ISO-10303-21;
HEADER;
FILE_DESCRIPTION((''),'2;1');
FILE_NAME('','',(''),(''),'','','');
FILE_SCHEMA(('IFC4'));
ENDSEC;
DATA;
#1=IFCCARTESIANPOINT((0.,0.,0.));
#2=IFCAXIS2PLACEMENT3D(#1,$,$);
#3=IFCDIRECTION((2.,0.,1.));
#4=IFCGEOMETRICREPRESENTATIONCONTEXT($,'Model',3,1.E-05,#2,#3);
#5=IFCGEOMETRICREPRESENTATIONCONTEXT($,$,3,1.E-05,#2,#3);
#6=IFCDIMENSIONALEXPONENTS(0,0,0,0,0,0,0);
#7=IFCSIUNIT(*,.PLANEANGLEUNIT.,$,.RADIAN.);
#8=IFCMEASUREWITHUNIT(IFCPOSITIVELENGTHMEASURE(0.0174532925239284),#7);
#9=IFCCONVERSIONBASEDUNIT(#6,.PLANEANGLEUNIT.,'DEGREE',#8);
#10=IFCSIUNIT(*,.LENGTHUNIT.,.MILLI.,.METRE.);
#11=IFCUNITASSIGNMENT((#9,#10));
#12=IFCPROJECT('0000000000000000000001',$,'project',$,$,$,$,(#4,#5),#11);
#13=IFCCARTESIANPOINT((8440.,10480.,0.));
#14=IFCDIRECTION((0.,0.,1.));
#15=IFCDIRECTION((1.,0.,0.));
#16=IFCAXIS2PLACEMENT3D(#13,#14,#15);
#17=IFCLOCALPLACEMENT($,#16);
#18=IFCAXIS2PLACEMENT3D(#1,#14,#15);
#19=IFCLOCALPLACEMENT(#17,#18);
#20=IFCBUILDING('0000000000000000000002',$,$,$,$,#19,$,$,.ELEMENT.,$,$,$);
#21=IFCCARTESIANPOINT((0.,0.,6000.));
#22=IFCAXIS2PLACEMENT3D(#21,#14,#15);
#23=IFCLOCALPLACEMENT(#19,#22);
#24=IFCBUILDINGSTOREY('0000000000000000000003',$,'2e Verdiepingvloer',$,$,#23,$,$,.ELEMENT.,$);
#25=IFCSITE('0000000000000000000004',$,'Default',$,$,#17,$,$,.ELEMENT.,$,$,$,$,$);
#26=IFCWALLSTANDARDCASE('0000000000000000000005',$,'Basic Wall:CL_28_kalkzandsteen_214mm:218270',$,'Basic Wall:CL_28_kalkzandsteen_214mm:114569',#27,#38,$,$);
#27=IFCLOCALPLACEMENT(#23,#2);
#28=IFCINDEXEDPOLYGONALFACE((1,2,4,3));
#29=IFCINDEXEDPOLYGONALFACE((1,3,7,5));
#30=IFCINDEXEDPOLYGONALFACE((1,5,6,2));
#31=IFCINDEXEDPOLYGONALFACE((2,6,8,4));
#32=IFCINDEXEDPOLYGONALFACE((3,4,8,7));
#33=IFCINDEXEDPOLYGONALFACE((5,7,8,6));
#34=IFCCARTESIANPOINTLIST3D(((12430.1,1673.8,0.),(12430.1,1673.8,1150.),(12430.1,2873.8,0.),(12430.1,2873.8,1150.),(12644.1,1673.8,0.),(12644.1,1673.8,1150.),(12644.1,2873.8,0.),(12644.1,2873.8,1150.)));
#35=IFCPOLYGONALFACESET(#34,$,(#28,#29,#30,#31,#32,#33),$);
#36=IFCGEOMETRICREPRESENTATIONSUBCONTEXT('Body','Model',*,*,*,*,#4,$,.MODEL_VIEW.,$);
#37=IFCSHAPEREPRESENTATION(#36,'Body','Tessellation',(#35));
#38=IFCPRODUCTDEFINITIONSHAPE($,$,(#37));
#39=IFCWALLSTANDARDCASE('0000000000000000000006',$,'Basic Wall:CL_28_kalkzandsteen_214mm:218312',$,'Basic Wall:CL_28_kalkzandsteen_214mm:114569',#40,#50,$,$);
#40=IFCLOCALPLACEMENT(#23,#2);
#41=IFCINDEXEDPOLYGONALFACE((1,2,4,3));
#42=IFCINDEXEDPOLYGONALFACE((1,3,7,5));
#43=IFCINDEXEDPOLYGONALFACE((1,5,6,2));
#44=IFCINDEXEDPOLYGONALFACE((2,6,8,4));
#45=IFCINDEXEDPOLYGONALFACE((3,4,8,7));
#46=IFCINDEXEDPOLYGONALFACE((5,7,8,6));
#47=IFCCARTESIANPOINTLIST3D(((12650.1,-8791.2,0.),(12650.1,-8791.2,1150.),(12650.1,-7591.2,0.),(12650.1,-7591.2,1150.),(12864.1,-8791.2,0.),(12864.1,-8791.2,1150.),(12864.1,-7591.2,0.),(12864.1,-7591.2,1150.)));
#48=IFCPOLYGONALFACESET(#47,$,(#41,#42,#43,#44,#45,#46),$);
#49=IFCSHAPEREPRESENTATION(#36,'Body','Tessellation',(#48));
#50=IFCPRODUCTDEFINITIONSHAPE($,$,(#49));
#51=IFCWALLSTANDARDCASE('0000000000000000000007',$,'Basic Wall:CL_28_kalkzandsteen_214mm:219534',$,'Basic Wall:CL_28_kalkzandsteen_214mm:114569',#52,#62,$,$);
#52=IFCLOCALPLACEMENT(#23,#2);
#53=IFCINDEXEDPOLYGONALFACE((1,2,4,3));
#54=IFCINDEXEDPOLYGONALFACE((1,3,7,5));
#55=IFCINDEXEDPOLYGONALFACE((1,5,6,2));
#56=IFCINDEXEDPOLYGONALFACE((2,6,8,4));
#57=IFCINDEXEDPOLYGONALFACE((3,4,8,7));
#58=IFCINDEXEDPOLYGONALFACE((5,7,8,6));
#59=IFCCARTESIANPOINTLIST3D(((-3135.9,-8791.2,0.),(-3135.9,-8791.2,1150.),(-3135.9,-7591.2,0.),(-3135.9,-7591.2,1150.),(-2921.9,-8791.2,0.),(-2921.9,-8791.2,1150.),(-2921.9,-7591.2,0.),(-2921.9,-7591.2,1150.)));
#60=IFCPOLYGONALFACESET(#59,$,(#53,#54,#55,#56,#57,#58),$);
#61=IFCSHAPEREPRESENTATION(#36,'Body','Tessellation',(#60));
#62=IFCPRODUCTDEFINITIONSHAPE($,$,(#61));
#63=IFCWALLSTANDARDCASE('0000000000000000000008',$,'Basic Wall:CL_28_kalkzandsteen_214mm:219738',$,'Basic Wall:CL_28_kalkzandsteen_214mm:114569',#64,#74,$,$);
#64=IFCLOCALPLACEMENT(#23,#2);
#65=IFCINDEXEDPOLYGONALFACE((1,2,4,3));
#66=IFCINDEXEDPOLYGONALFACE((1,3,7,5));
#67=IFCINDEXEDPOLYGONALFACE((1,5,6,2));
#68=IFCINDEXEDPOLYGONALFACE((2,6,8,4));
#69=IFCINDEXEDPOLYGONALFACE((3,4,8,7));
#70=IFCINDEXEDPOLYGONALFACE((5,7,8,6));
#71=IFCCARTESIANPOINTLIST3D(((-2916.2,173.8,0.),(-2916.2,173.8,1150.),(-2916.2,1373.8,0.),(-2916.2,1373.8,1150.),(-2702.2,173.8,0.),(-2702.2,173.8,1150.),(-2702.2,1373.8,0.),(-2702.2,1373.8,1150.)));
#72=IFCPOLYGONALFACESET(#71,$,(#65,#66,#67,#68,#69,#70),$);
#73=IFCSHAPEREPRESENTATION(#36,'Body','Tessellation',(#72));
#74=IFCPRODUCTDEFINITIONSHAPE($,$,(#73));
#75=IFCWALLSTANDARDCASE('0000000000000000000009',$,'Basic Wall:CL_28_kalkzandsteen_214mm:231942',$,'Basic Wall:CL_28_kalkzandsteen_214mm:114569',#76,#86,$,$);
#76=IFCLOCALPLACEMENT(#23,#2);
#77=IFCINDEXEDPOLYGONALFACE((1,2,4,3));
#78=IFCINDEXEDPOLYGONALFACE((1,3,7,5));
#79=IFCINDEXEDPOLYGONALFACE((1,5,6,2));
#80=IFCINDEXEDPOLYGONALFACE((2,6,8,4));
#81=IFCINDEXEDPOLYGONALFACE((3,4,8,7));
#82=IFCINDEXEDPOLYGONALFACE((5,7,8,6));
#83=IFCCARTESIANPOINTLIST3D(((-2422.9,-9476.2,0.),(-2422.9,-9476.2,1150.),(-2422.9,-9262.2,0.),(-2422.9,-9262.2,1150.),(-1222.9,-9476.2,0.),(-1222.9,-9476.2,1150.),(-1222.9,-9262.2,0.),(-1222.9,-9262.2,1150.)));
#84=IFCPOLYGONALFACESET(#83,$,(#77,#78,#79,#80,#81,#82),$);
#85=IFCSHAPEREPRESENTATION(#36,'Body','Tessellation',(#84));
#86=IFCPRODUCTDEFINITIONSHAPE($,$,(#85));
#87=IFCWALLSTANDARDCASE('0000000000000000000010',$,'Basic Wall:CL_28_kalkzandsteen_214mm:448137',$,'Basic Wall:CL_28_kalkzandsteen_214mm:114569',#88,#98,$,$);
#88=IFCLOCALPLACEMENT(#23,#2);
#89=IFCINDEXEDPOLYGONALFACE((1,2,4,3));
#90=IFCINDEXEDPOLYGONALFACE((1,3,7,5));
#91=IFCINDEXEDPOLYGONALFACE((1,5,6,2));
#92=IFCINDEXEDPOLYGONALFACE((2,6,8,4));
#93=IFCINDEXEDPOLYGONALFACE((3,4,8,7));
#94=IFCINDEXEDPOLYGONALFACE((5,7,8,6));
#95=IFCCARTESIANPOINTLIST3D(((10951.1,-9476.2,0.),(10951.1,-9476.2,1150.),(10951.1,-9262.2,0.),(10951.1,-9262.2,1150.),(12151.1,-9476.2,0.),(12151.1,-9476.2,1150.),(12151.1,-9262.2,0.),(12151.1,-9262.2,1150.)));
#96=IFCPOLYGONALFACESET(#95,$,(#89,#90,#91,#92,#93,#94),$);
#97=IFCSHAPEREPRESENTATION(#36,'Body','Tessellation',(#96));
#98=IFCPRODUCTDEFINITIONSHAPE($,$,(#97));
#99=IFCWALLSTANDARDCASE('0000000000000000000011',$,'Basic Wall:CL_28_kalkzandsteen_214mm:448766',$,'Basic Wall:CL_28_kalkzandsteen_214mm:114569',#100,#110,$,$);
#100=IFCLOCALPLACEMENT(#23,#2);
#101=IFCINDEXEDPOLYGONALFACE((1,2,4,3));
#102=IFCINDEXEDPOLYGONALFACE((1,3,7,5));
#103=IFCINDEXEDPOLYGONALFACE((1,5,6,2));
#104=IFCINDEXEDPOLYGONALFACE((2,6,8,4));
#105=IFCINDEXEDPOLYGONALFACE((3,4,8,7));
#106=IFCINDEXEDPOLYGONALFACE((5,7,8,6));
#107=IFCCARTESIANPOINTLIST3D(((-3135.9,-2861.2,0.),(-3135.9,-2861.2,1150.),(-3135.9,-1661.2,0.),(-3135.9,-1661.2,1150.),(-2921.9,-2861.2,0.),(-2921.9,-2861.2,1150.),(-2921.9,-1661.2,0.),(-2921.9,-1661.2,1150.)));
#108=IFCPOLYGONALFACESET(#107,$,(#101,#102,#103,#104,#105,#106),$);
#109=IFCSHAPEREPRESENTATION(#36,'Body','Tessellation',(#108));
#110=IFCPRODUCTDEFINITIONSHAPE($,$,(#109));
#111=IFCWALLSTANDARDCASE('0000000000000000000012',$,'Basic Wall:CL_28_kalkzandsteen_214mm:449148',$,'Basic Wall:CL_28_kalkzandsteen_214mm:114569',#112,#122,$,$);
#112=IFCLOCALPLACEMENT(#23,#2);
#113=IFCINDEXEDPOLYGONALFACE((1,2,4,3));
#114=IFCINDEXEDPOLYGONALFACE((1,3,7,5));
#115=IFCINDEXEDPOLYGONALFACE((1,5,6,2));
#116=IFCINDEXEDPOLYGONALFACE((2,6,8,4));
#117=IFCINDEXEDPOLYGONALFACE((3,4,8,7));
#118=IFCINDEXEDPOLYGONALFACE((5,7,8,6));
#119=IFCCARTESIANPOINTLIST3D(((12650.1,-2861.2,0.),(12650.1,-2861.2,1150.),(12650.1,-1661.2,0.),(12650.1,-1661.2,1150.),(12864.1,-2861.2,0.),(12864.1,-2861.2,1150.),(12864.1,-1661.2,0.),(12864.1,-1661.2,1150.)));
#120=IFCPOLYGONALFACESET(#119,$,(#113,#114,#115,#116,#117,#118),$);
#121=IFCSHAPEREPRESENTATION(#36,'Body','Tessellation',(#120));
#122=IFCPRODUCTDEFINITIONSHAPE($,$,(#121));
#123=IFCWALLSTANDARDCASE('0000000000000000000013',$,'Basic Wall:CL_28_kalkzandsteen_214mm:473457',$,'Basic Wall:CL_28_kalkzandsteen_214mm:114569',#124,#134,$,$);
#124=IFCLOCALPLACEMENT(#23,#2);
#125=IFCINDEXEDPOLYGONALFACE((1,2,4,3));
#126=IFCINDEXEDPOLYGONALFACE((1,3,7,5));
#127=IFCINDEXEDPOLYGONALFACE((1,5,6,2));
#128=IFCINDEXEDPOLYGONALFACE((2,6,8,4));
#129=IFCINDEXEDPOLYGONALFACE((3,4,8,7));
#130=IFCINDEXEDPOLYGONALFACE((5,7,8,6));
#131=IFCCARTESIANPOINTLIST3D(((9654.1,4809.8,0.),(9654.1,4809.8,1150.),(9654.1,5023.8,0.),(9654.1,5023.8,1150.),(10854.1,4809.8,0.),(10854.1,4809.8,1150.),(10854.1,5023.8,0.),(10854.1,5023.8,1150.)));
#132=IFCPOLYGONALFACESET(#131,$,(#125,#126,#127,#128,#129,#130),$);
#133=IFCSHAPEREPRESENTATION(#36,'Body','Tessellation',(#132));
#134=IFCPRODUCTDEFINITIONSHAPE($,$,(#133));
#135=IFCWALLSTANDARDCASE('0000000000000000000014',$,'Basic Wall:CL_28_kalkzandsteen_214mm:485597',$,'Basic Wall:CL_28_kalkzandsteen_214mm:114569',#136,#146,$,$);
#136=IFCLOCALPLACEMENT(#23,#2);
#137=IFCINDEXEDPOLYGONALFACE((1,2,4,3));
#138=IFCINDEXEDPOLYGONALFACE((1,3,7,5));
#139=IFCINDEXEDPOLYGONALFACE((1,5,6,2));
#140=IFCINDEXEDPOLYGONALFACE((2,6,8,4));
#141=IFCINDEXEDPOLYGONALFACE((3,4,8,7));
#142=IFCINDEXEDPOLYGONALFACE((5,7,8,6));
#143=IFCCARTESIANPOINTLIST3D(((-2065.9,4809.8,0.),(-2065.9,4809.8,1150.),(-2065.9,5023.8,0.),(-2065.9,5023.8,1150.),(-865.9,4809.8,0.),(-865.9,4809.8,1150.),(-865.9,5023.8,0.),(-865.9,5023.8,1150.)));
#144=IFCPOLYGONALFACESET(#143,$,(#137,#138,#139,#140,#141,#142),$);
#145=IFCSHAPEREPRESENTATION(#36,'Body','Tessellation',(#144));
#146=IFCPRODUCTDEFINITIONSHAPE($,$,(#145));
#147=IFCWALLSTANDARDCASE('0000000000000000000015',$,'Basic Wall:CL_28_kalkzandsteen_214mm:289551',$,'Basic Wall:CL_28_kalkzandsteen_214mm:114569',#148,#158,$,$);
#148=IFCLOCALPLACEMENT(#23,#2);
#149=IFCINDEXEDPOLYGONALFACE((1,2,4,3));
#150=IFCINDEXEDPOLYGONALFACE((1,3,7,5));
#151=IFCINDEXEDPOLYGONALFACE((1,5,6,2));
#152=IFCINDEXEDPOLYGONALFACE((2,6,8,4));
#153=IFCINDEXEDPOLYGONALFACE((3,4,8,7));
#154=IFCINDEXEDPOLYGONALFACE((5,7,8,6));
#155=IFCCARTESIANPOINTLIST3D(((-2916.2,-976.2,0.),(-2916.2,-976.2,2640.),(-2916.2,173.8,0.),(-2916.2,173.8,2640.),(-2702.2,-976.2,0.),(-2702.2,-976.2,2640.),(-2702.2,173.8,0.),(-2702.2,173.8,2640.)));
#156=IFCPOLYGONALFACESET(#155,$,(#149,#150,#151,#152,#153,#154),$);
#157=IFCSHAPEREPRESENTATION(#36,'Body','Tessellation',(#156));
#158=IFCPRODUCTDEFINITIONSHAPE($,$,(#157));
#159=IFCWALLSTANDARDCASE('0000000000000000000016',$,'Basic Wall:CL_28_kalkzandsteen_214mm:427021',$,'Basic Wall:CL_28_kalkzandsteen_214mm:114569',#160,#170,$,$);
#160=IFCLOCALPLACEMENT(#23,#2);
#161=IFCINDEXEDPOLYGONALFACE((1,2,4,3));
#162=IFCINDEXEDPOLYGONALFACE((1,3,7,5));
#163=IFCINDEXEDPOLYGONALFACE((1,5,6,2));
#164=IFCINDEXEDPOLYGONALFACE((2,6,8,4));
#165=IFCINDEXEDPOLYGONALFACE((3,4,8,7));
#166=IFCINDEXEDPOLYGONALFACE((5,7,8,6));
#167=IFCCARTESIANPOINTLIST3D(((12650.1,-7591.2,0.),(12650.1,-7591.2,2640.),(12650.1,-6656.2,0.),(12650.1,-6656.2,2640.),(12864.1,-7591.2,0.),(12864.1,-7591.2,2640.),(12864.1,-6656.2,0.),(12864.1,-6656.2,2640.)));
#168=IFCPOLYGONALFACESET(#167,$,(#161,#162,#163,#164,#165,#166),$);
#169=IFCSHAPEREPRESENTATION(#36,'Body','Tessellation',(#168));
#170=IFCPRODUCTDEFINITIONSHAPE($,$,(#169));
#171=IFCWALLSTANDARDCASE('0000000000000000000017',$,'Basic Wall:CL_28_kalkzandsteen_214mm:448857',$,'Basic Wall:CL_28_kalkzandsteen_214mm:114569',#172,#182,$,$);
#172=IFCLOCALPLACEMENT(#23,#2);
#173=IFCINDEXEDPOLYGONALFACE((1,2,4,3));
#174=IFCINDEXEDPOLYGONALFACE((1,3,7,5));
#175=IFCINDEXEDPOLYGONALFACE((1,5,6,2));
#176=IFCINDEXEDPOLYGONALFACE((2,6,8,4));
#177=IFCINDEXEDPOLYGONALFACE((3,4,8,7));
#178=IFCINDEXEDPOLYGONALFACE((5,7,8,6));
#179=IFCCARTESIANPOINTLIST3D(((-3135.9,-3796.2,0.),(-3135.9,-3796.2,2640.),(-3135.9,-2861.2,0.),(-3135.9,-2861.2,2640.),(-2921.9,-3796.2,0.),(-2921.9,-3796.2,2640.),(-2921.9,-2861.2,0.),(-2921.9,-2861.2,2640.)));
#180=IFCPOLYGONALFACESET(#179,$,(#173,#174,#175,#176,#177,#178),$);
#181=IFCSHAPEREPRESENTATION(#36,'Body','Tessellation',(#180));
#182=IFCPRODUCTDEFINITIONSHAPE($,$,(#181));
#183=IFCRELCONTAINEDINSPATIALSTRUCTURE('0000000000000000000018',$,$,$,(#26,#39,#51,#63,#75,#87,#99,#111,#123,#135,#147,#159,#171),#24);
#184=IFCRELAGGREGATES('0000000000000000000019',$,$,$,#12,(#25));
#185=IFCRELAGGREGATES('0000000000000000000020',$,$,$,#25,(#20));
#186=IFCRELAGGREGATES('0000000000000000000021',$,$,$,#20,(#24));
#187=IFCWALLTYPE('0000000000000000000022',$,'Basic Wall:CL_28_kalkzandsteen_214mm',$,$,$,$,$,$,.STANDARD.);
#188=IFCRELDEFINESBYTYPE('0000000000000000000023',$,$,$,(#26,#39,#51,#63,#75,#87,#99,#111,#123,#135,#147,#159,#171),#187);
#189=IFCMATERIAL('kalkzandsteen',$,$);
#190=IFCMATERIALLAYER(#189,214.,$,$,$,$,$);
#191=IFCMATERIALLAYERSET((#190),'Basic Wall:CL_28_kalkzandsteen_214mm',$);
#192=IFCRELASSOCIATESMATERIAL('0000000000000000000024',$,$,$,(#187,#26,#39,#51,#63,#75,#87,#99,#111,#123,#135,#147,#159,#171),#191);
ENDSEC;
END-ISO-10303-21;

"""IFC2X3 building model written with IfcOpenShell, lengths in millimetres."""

from ifc_helpers import new_model, entity, si_unit, converted_unit, direction, frame, frame_2d, origin, origin_with_axes, place, context, subcontext, project, spatial, rectangle, extrude, source, transform, mapped, material, layer, layer_set, layer_usage, type_object, element, save


model = new_model("IFC2X3")

# Units and contexts
model_context = context("Model", 3, precision=1e-05, world=origin(), true_north=direction((2.0, 0.0, 1.0)))
context_of_model = context(None, 3, precision=1e-05, world=origin(), true_north=direction((2.0, 0.0, 1.0)))
body_context = subcontext(model_context, "Body", "Model", "MODEL_VIEW")
ifc_project = project(units=[converted_unit("PLANEANGLEUNIT", "DEGREE", entity("IfcPositiveLengthMeasure", 0.0174532925239284), si_unit("PLANEANGLEUNIT", "RADIAN"), dimensions=[0, 0, 0, 0, 0, 0, 0]), si_unit("LENGTHUNIT", "METRE", prefix="MILLI")], contexts=[model_context, context_of_model])

# Site, building, storey
site_placement = place(None, frame((8440.0, 10480.0, 0.0), z_axis=(0.0, 0.0, 1.0), x_axis=(1.0, 0.0, 0.0)))
site = spatial("IfcSite", under=ifc_project, at=site_placement, Name="Default", CompositionType="ELEMENT")
building_placement = place(site_placement, origin_with_axes())
building = spatial("IfcBuilding", under=site, at=building_placement, CompositionType="ELEMENT")
storey_placement = place(building_placement, frame((0.0, 0.0, 6000.0), z_axis=(0.0, 0.0, 1.0), x_axis=(1.0, 0.0, 0.0)))
storey = spatial("IfcBuildingStorey", under=building, at=storey_placement, Name="2e Verdiepingvloer", CompositionType="ELEMENT")

# Walls
ifc_material_1 = material(Name="kalkzandsteen")
ifc_layer_1 = layer(ifc_material_1, 214.0)
ifc_layer_set_1 = layer_set([ifc_layer_1], Name="Basic Wall:CL_28_kalkzandsteen_214mm")
ifc_layer_usage_1 = layer_usage(ifc_layer_set_1, "AXIS2", "NEGATIVE", 107.0)
wall_type_1 = type_object("IfcWallType", Name="Basic Wall:CL_28_kalkzandsteen_214mm", PredefinedType="STANDARD", material=ifc_layer_set_1)
shared_shape_1 = source(origin(), body_context, "Body", "SweptSolid", [
    extrude(rectangle(XDim=1200.0, YDim=214.0, at=frame_2d((600.0, 0.0), x_axis=(-1.0, 0.0))), origin(), (0.0, 0.0, 1.0), 1150.0),
])
wall_1_placement = place(storey_placement, frame((12537.1, 1673.8, 0.0), z_axis=(0.0, 0.0, 1.0), x_axis=(0.0, 1.0, 0.0)))
element("IfcWallStandardCase", 1, at=wall_1_placement, inside=storey, type_object=wall_type_1, material=ifc_layer_usage_1, Name="Basic Wall:CL_28_kalkzandsteen_214mm:218270", ObjectType="Basic Wall:CL_28_kalkzandsteen_214mm:114569", context=body_context, shape_type="MappedRepresentation", body=[
    mapped(shared_shape_1, transform((0.0, 0.0, 0.0))),
])
ifc_layer_usage_2 = layer_usage(ifc_layer_set_1, "AXIS2", "NEGATIVE", 107.0)
wall_2_placement = place(storey_placement, frame((12757.1, -8791.2, 0.0), z_axis=(0.0, 0.0, 1.0), x_axis=(0.0, 1.0, 0.0)))
element("IfcWallStandardCase", 2, at=wall_2_placement, inside=storey, type_object=wall_type_1, material=ifc_layer_usage_2, Name="Basic Wall:CL_28_kalkzandsteen_214mm:218312", ObjectType="Basic Wall:CL_28_kalkzandsteen_214mm:114569", context=body_context, shape_type="MappedRepresentation", body=[
    mapped(shared_shape_1, transform((0.0, 0.0, 0.0))),
])
ifc_layer_usage_3 = layer_usage(ifc_layer_set_1, "AXIS2", "NEGATIVE", 107.0)
wall_3_placement = place(storey_placement, frame((-3028.9, -7591.2, 0.0), z_axis=(0.0, 0.0, 1.0), x_axis=(0.0, -1.0, 0.0)))
element("IfcWallStandardCase", 3, at=wall_3_placement, inside=storey, type_object=wall_type_1, material=ifc_layer_usage_3, Name="Basic Wall:CL_28_kalkzandsteen_214mm:219534", ObjectType="Basic Wall:CL_28_kalkzandsteen_214mm:114569", context=body_context, shape_type="MappedRepresentation", body=[
    mapped(shared_shape_1, transform((0.0, 0.0, 0.0))),
])
ifc_layer_usage_4 = layer_usage(ifc_layer_set_1, "AXIS2", "NEGATIVE", 107.0)
wall_4_placement = place(storey_placement, frame((-2809.2, 1373.8, 0.0), z_axis=(0.0, 0.0, 1.0), x_axis=(0.0, -1.0, 0.0)))
element("IfcWallStandardCase", 4, at=wall_4_placement, inside=storey, type_object=wall_type_1, material=ifc_layer_usage_4, Name="Basic Wall:CL_28_kalkzandsteen_214mm:219738", ObjectType="Basic Wall:CL_28_kalkzandsteen_214mm:114569", context=body_context, shape_type="MappedRepresentation", body=[
    mapped(shared_shape_1, transform((0.0, 0.0, 0.0))),
])
ifc_layer_usage_5 = layer_usage(ifc_layer_set_1, "AXIS2", "NEGATIVE", 107.0)
wall_5_placement = place(storey_placement, frame((-2422.9, -9369.2, 0.0), z_axis=(0.0, 0.0, 1.0), x_axis=(1.0, 0.0, 0.0)))
element("IfcWallStandardCase", 5, at=wall_5_placement, inside=storey, type_object=wall_type_1, material=ifc_layer_usage_5, Name="Basic Wall:CL_28_kalkzandsteen_214mm:231942", ObjectType="Basic Wall:CL_28_kalkzandsteen_214mm:114569", context=body_context, shape_type="MappedRepresentation", body=[
    mapped(shared_shape_1, transform((0.0, 0.0, 0.0))),
])
ifc_layer_usage_6 = layer_usage(ifc_layer_set_1, "AXIS2", "NEGATIVE", 107.0)
wall_6_placement = place(storey_placement, frame((10951.1, -9369.2, 0.0), z_axis=(0.0, 0.0, 1.0), x_axis=(1.0, 0.0, 0.0)))
element("IfcWallStandardCase", 6, at=wall_6_placement, inside=storey, type_object=wall_type_1, material=ifc_layer_usage_6, Name="Basic Wall:CL_28_kalkzandsteen_214mm:448137", ObjectType="Basic Wall:CL_28_kalkzandsteen_214mm:114569", context=body_context, shape_type="MappedRepresentation", body=[
    mapped(shared_shape_1, transform((0.0, 0.0, 0.0))),
])
ifc_layer_usage_7 = layer_usage(ifc_layer_set_1, "AXIS2", "NEGATIVE", 107.0)
wall_7_placement = place(storey_placement, frame((-3028.9, -1661.2, 0.0), z_axis=(0.0, 0.0, 1.0), x_axis=(0.0, -1.0, 0.0)))
element("IfcWallStandardCase", 7, at=wall_7_placement, inside=storey, type_object=wall_type_1, material=ifc_layer_usage_7, Name="Basic Wall:CL_28_kalkzandsteen_214mm:448766", ObjectType="Basic Wall:CL_28_kalkzandsteen_214mm:114569", context=body_context, shape_type="MappedRepresentation", body=[
    mapped(shared_shape_1, transform((0.0, 0.0, 0.0))),
])
ifc_layer_usage_8 = layer_usage(ifc_layer_set_1, "AXIS2", "NEGATIVE", 107.0)
wall_8_placement = place(storey_placement, frame((12757.1, -2861.2, 0.0), z_axis=(0.0, 0.0, 1.0), x_axis=(0.0, 1.0, 0.0)))
element("IfcWallStandardCase", 8, at=wall_8_placement, inside=storey, type_object=wall_type_1, material=ifc_layer_usage_8, Name="Basic Wall:CL_28_kalkzandsteen_214mm:449148", ObjectType="Basic Wall:CL_28_kalkzandsteen_214mm:114569", context=body_context, shape_type="MappedRepresentation", body=[
    mapped(shared_shape_1, transform((0.0, 0.0, 0.0))),
])
ifc_layer_usage_9 = layer_usage(ifc_layer_set_1, "AXIS2", "NEGATIVE", 107.0)
wall_9_placement = place(storey_placement, frame((10854.1, 4916.8, 0.0), z_axis=(0.0, 0.0, 1.0), x_axis=(-1.0, 0.0, 0.0)))
element("IfcWallStandardCase", 9, at=wall_9_placement, inside=storey, type_object=wall_type_1, material=ifc_layer_usage_9, Name="Basic Wall:CL_28_kalkzandsteen_214mm:473457", ObjectType="Basic Wall:CL_28_kalkzandsteen_214mm:114569", context=body_context, shape_type="MappedRepresentation", body=[
    mapped(shared_shape_1, transform((0.0, 0.0, 0.0))),
])
ifc_layer_usage_10 = layer_usage(ifc_layer_set_1, "AXIS2", "NEGATIVE", 107.0)
wall_10_placement = place(storey_placement, frame((-865.9, 4916.8, 0.0), z_axis=(0.0, 0.0, 1.0), x_axis=(-1.0, 0.0, 0.0)))
element("IfcWallStandardCase", 10, at=wall_10_placement, inside=storey, type_object=wall_type_1, material=ifc_layer_usage_10, Name="Basic Wall:CL_28_kalkzandsteen_214mm:485597", ObjectType="Basic Wall:CL_28_kalkzandsteen_214mm:114569", context=body_context, shape_type="MappedRepresentation", body=[
    mapped(shared_shape_1, transform((0.0, 0.0, 0.0))),
])
ifc_layer_usage_11 = layer_usage(ifc_layer_set_1, "AXIS2", "NEGATIVE", 107.0)
shared_shape_2 = source(origin(), body_context, "Body", "SweptSolid", [
    extrude(rectangle(XDim=1150.0, YDim=214.0, at=frame_2d((575.0, 0.0), x_axis=(-1.0, 0.0))), origin(), (0.0, 0.0, 1.0), 2640.0),
])
wall_11_placement = place(storey_placement, frame((-2809.2, 173.8, 0.0), z_axis=(0.0, 0.0, 1.0), x_axis=(0.0, -1.0, 0.0)))
element("IfcWallStandardCase", 11, at=wall_11_placement, inside=storey, type_object=wall_type_1, material=ifc_layer_usage_11, Name="Basic Wall:CL_28_kalkzandsteen_214mm:289551", ObjectType="Basic Wall:CL_28_kalkzandsteen_214mm:114569", context=body_context, shape_type="MappedRepresentation", body=[
    mapped(shared_shape_2, transform((0.0, 0.0, 0.0))),
])
ifc_layer_usage_12 = layer_usage(ifc_layer_set_1, "AXIS2", "NEGATIVE", 107.0)
shared_shape_3 = source(origin(), body_context, "Body", "SweptSolid", [
    extrude(rectangle(XDim=935.0, YDim=214.0, at=frame_2d((467.5, 0.0), x_axis=(-1.0, 0.0))), origin(), (0.0, 0.0, 1.0), 2640.0),
])
wall_12_placement = place(storey_placement, frame((12757.1, -7591.2, 0.0), z_axis=(0.0, 0.0, 1.0), x_axis=(0.0, 1.0, 0.0)))
element("IfcWallStandardCase", 12, at=wall_12_placement, inside=storey, type_object=wall_type_1, material=ifc_layer_usage_12, Name="Basic Wall:CL_28_kalkzandsteen_214mm:427021", ObjectType="Basic Wall:CL_28_kalkzandsteen_214mm:114569", context=body_context, shape_type="MappedRepresentation", body=[
    mapped(shared_shape_3, transform((0.0, 0.0, 0.0))),
])
ifc_layer_usage_13 = layer_usage(ifc_layer_set_1, "AXIS2", "NEGATIVE", 107.0)
wall_13_placement = place(storey_placement, frame((-3028.9, -2861.2, 0.0), z_axis=(0.0, 0.0, 1.0), x_axis=(0.0, -1.0, 0.0)))
element("IfcWallStandardCase", 13, at=wall_13_placement, inside=storey, type_object=wall_type_1, material=ifc_layer_usage_13, Name="Basic Wall:CL_28_kalkzandsteen_214mm:448857", ObjectType="Basic Wall:CL_28_kalkzandsteen_214mm:114569", context=body_context, shape_type="MappedRepresentation", body=[
    mapped(shared_shape_3, transform((0.0, 0.0, 0.0))),
])

save(model, "model.ifc")
